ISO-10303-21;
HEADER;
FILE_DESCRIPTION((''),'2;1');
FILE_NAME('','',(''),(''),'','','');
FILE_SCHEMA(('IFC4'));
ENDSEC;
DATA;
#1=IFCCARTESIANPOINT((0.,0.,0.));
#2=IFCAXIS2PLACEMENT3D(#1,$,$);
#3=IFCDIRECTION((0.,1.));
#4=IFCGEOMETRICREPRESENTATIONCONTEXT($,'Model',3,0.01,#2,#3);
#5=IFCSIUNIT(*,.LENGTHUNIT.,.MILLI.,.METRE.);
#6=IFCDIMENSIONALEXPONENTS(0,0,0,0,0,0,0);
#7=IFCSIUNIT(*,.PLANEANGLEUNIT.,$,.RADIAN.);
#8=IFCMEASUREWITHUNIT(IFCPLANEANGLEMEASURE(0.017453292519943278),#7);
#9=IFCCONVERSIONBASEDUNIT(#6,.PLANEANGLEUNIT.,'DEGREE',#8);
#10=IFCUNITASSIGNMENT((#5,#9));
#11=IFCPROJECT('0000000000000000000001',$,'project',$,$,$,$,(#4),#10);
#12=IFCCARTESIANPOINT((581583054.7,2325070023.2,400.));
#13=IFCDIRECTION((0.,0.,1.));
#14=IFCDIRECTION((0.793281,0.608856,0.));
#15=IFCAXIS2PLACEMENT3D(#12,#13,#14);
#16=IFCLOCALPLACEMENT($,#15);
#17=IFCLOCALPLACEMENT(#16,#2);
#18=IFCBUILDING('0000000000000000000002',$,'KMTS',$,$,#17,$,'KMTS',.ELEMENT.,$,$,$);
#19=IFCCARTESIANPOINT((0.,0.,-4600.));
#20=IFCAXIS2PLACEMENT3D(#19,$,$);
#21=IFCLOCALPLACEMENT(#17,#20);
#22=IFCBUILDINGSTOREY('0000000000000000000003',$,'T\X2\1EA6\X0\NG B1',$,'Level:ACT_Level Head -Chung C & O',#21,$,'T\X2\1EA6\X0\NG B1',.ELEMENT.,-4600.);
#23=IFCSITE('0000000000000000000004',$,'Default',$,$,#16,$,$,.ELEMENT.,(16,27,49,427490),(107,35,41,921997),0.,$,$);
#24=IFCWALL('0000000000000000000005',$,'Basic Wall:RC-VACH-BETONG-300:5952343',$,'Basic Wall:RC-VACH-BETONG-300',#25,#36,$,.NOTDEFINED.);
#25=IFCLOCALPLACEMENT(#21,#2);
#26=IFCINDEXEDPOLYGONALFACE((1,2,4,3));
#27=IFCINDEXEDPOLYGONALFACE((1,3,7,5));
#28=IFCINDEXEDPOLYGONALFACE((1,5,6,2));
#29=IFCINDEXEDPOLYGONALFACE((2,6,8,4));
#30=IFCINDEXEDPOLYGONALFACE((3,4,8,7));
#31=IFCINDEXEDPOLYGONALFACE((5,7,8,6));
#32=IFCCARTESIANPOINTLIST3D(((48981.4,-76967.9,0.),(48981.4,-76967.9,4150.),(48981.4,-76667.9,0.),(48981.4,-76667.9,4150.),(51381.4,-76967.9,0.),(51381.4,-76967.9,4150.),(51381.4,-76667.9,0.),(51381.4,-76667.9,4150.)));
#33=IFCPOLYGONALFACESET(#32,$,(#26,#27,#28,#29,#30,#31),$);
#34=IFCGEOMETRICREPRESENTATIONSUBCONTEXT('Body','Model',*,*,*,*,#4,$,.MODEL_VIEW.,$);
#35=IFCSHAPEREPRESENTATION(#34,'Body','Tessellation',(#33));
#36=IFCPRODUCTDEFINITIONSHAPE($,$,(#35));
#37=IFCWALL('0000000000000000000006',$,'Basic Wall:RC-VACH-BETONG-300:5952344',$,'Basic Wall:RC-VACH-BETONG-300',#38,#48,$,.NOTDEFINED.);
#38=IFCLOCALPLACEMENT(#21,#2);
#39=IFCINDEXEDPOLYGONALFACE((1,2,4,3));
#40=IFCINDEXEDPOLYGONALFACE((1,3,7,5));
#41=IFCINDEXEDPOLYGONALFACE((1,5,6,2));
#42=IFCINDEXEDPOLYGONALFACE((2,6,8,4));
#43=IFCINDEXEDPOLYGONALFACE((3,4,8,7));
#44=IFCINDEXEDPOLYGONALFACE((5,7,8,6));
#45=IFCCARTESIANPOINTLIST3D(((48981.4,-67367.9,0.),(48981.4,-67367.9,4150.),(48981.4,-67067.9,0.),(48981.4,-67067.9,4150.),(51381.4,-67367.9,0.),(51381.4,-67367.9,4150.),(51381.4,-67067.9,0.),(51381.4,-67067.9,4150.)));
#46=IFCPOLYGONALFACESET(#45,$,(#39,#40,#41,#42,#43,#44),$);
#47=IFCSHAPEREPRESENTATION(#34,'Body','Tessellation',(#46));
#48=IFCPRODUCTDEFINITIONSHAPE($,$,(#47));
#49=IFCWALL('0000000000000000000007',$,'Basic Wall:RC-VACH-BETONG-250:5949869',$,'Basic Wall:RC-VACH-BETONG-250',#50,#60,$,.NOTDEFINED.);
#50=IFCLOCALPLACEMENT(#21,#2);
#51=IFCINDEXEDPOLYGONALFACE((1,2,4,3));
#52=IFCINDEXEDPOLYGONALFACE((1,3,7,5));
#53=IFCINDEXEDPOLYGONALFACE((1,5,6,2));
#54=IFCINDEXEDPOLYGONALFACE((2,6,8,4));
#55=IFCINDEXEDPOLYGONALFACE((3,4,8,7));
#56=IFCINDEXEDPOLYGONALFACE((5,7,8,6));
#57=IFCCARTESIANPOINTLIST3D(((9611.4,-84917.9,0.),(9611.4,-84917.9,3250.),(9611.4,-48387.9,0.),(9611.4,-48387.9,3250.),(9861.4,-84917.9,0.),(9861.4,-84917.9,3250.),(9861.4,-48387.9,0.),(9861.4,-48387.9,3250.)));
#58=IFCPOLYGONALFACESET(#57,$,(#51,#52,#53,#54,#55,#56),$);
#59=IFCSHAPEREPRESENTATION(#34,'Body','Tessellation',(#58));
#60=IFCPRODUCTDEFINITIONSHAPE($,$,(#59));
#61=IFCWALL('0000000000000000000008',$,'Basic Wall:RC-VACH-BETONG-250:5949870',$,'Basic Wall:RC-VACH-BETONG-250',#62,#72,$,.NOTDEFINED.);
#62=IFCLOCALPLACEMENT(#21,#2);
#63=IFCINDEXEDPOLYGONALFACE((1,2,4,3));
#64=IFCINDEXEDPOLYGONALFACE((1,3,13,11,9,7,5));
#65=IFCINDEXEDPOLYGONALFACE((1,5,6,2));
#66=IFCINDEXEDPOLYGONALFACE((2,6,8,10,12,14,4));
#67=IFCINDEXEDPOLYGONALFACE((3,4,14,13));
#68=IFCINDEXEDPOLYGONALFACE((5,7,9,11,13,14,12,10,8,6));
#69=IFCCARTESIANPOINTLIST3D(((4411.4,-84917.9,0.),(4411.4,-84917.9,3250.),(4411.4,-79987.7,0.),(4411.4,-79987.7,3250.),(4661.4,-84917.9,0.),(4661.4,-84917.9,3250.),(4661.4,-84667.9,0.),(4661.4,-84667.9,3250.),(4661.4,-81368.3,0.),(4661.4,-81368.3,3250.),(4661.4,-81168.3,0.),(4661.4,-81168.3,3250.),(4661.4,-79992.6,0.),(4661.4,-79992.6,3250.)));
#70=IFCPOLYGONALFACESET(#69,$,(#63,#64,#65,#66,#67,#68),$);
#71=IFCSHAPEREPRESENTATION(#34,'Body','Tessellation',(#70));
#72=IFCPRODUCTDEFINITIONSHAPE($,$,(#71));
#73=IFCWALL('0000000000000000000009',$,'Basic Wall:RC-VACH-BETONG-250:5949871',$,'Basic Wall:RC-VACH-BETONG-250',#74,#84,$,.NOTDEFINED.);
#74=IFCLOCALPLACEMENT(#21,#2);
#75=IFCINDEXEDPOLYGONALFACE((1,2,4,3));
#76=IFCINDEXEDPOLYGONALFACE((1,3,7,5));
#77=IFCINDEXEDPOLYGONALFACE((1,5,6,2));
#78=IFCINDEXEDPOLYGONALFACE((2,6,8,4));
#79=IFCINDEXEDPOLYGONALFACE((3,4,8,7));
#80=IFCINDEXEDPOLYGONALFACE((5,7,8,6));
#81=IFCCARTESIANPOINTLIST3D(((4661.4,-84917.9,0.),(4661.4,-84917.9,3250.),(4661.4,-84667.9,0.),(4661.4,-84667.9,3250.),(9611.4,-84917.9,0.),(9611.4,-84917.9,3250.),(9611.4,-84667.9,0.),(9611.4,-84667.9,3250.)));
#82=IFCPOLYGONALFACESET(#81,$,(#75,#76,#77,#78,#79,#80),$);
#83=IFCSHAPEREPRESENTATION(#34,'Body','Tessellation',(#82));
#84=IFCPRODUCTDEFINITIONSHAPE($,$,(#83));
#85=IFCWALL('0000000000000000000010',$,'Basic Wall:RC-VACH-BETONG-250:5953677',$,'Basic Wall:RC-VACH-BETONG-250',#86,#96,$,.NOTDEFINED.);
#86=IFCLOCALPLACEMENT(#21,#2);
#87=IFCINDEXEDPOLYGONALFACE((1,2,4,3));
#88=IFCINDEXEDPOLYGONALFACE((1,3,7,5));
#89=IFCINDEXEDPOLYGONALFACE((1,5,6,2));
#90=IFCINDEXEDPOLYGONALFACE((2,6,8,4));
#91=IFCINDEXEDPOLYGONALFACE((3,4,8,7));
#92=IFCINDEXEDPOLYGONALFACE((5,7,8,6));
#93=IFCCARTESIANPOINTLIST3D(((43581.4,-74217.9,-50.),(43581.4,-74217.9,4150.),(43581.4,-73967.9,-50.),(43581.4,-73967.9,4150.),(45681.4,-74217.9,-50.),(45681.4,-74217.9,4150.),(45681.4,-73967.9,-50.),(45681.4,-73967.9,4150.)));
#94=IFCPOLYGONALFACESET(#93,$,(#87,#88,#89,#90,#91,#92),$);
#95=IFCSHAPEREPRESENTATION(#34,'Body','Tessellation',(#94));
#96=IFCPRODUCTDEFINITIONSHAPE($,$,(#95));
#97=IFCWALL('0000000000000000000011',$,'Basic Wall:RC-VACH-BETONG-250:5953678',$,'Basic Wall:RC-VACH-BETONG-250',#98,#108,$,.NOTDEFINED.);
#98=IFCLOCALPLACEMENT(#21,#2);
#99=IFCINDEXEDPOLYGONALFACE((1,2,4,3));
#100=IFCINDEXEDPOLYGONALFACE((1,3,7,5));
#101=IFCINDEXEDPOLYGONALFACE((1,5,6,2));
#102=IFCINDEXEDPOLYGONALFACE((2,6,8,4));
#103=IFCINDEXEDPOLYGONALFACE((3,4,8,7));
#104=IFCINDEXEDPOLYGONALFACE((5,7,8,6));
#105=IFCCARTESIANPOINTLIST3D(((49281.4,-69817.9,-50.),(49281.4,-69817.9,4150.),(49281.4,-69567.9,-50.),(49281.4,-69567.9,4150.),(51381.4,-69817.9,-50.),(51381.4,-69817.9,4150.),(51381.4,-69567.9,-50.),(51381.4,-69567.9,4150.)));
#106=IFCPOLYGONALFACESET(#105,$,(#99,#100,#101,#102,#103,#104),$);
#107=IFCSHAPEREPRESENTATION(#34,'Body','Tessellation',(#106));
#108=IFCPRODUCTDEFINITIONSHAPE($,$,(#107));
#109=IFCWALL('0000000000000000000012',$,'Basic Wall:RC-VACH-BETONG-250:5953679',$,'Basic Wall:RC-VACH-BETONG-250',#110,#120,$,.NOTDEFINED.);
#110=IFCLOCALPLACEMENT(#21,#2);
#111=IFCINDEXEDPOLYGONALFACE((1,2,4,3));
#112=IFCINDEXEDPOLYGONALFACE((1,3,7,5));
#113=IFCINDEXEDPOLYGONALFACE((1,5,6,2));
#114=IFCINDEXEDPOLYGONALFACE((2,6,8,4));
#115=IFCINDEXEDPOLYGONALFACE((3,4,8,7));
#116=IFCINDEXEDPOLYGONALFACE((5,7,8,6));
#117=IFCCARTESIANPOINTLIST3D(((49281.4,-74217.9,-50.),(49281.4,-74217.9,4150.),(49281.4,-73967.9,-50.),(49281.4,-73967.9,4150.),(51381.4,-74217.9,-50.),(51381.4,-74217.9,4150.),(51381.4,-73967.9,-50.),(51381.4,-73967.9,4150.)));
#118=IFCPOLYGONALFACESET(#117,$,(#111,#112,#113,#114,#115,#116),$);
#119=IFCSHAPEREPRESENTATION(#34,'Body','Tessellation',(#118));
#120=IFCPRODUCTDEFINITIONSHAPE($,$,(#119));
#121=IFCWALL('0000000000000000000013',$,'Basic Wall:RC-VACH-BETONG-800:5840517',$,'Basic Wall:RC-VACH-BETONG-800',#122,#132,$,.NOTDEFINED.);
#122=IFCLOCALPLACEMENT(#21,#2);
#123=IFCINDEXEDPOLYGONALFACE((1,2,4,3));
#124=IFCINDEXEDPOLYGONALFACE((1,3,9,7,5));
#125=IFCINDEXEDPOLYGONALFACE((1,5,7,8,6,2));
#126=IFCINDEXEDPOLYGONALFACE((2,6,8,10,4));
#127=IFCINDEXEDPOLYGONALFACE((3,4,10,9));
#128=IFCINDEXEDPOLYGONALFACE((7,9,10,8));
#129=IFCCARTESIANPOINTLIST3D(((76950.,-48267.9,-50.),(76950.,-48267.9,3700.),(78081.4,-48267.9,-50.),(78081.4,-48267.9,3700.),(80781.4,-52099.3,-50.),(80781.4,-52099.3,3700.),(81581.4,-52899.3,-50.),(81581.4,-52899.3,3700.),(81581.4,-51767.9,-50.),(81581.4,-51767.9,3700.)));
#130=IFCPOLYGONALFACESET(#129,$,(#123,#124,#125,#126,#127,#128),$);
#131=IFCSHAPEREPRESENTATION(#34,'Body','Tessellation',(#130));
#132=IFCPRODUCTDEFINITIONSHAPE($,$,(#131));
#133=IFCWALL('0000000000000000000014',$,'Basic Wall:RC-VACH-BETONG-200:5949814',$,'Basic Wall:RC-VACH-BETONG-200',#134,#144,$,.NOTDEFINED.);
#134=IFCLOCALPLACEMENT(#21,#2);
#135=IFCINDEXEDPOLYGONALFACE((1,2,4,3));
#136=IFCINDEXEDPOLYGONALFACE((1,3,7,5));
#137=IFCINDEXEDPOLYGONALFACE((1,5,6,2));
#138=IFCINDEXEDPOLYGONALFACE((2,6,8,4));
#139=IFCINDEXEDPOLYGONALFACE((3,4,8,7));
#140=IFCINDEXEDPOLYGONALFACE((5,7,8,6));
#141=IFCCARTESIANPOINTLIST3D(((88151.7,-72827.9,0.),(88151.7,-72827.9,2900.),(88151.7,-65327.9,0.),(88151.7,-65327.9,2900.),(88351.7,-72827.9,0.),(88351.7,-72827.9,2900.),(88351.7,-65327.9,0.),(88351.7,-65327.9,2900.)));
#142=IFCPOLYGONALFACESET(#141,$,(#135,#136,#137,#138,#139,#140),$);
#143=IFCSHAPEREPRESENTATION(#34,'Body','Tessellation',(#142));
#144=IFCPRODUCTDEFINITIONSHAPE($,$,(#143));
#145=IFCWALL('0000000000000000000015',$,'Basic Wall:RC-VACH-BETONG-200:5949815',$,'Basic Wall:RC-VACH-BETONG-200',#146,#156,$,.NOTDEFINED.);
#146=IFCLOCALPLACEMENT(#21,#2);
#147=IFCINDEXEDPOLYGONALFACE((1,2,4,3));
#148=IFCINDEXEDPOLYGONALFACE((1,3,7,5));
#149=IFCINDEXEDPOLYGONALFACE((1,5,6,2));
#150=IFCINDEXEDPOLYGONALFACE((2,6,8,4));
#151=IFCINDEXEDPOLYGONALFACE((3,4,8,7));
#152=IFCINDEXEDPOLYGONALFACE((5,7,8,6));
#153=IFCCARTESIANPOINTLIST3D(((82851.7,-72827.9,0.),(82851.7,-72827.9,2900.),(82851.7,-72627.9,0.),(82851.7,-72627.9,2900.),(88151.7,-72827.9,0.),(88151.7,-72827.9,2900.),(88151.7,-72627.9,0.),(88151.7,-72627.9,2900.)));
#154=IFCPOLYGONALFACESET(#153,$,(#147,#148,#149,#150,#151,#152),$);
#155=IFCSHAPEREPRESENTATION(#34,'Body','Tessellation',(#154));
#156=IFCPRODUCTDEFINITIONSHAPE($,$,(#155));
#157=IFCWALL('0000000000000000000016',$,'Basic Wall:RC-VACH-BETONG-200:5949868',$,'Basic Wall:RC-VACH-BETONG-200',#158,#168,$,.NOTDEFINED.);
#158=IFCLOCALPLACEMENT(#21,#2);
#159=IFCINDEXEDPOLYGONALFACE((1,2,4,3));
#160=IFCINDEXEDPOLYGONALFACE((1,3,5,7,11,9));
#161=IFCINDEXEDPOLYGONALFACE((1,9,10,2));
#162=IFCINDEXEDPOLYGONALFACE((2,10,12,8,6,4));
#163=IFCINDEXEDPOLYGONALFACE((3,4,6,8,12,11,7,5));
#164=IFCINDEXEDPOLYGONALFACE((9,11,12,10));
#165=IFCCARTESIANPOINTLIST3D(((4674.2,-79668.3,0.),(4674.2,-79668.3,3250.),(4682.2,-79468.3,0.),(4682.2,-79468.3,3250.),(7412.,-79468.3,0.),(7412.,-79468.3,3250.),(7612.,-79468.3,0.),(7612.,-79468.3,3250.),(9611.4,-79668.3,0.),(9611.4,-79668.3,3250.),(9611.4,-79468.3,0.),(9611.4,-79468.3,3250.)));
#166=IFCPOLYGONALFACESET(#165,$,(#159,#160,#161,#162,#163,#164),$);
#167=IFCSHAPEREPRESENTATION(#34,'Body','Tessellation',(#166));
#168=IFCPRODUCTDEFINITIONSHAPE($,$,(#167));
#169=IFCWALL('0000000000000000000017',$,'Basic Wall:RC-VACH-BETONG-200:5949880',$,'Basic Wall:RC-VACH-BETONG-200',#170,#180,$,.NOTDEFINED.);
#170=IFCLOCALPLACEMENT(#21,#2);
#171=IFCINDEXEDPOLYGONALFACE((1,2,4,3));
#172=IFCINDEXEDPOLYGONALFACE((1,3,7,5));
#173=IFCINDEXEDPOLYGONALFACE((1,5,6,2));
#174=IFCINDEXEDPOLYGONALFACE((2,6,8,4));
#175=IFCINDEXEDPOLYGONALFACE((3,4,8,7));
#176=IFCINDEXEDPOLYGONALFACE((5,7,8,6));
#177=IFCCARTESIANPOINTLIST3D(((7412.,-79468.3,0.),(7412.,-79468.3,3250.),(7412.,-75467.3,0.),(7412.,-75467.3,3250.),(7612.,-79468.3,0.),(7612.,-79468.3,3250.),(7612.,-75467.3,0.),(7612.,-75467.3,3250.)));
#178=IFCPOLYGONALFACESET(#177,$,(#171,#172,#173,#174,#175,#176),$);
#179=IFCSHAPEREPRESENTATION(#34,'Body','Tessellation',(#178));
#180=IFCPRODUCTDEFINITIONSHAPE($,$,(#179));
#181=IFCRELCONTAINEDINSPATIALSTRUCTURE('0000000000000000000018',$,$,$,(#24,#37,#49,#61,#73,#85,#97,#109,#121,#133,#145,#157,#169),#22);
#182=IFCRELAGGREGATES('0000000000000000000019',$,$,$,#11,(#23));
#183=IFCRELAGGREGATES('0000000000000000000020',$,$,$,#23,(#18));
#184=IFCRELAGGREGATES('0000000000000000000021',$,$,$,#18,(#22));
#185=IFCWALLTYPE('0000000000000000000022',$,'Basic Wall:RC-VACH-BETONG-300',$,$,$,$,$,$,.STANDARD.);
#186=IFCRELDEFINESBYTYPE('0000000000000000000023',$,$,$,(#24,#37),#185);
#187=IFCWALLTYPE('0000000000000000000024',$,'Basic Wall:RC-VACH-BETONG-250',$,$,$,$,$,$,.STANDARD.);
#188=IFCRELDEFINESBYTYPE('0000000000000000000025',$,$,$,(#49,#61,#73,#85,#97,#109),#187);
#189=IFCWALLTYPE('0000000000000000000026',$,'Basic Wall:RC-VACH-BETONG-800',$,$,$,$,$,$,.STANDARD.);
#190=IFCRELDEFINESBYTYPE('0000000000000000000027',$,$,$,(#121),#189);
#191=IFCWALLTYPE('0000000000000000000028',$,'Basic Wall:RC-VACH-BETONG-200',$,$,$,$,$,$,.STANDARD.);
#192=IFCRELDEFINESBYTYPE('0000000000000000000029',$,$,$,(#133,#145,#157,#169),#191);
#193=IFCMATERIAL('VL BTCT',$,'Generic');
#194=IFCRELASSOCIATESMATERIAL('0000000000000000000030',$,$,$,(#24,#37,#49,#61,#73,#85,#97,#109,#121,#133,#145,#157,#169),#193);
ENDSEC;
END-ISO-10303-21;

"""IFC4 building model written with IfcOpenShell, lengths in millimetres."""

from ifc_helpers import new_model, entity, si_unit, converted_unit, direction, frame, origin, place, context, subcontext, project, spatial, indexed_curve, outline, extrude, material, type_object, element, save


model = new_model("IFC4")

# Units and contexts
model_context = context("Model", 3, precision=0.01, world=origin(), true_north=direction((0.0, 1.0)))
body_context = subcontext(model_context, "Body", "Model", "MODEL_VIEW")
ifc_project = project(units=[si_unit("LENGTHUNIT", "METRE", prefix="MILLI"), converted_unit("PLANEANGLEUNIT", "DEGREE", entity("IfcPlaneAngleMeasure", 0.017453292519943278), si_unit("PLANEANGLEUNIT", "RADIAN"), dimensions=[0, 0, 0, 0, 0, 0, 0])], contexts=[model_context])

# Site, building, storey
site_placement = place(None, frame((581583054.7, 2325070023.2, 400.0), z_axis=(0.0, 0.0, 1.0), x_axis=(0.793281, 0.608856, 0.0)))
site = spatial("IfcSite", under=ifc_project, at=site_placement, Name="Default", CompositionType="ELEMENT", RefLatitude=(16, 27, 49, 427490), RefLongitude=(107, 35, 41, 921997), RefElevation=0.0)
building_placement = place(site_placement, origin())
building = spatial("IfcBuilding", under=site, at=building_placement, Name="KMTS", LongName="KMTS", CompositionType="ELEMENT")
storey_placement = place(building_placement, frame((0.0, 0.0, -4600.0)))
storey = spatial("IfcBuildingStorey", under=building, at=storey_placement, Name="TẦNG B1", ObjectType="Level:ACT_Level Head -Chung C & O", LongName="TẦNG B1", CompositionType="ELEMENT", Elevation=-4600.0)

# Shared definitions
ifc_material_1 = material(Name="VL BTCT", Category="Generic")

# Walls
wall_type_1 = type_object("IfcWallType", Name="Basic Wall:RC-VACH-BETONG-300", PredefinedType="STANDARD")
wall_1_placement = place(storey_placement, frame((51381.4, -76817.9, 0.0), z_axis=(0.0, 0.0, 1.0), x_axis=(-1.0, 0.0, 0.0)))
element("IfcWall", 1, at=wall_1_placement, inside=storey, type_object=wall_type_1, material=ifc_material_1, Name="Basic Wall:RC-VACH-BETONG-300:5952343", ObjectType="Basic Wall:RC-VACH-BETONG-300", PredefinedType="NOTDEFINED", context=body_context, shape_type="SweptSolid", body=[
    extrude(outline(indexed_curve([(2400.0, 150.0), (0.0, 150.0), (0.0, -150.0), (2400.0, -150.0), (2400.0, 150.0)], self_intersect=False)), origin(), (0.0, 0.0, 1.0), 4150.0),
])
wall_2_placement = place(storey_placement, frame((51381.4, -67217.9, 0.0), z_axis=(0.0, 0.0, 1.0), x_axis=(-1.0, 0.0, 0.0)))
element("IfcWall", 2, at=wall_2_placement, inside=storey, type_object=wall_type_1, material=ifc_material_1, Name="Basic Wall:RC-VACH-BETONG-300:5952344", ObjectType="Basic Wall:RC-VACH-BETONG-300", PredefinedType="NOTDEFINED", context=body_context, shape_type="SweptSolid", body=[
    extrude(outline(indexed_curve([(2400.0, 150.0), (0.0, 150.0), (0.0, -150.0), (2400.0, -150.0), (2400.0, 150.0)], self_intersect=False)), origin(), (0.0, 0.0, 1.0), 4150.0),
])
wall_type_2 = type_object("IfcWallType", Name="Basic Wall:RC-VACH-BETONG-250", PredefinedType="STANDARD")
wall_3_placement = place(storey_placement, frame((9736.4, -84917.9, 0.0), z_axis=(0.0, 0.0, 1.0), x_axis=(0.0, 1.0, 0.0)))
element("IfcWall", 3, at=wall_3_placement, inside=storey, type_object=wall_type_2, material=ifc_material_1, Name="Basic Wall:RC-VACH-BETONG-250:5949869", ObjectType="Basic Wall:RC-VACH-BETONG-250", PredefinedType="NOTDEFINED", context=body_context, shape_type="SweptSolid", body=[
    extrude(outline(indexed_curve([(36530.0, 125.0), (0.0, 125.0), (0.0, -125.0), (36530.0, -125.0), (36530.0, 125.0)], self_intersect=False)), origin(), (0.0, 0.0, 1.0), 3250.0),
])
wall_4_placement = place(storey_placement, frame((4536.4, -84917.9, 0.0), z_axis=(0.0, 0.0, 1.0), x_axis=(0.0, 1.0, 0.0)))
element("IfcWall", 4, at=wall_4_placement, inside=storey, type_object=wall_type_2, material=ifc_material_1, Name="Basic Wall:RC-VACH-BETONG-250:5949870", ObjectType="Basic Wall:RC-VACH-BETONG-250", PredefinedType="NOTDEFINED", context=body_context, shape_type="SweptSolid", body=[
    extrude(outline(indexed_curve([(4925.3, -125.0), (4930.3, 125.0), (0.0, 125.0), (0.0, -125.0), (250.0, -125.0), (3549.7, -125.0), (3749.7, -125.0), (4925.3, -125.0)], self_intersect=False)), origin(), (0.0, 0.0, 1.0), 3250.0),
])
wall_5_placement = place(storey_placement, frame((9611.4, -84792.9, 0.0), z_axis=(0.0, 0.0, 1.0), x_axis=(-1.0, 0.0, 0.0)))
element("IfcWall", 5, at=wall_5_placement, inside=storey, type_object=wall_type_2, material=ifc_material_1, Name="Basic Wall:RC-VACH-BETONG-250:5949871", ObjectType="Basic Wall:RC-VACH-BETONG-250", PredefinedType="NOTDEFINED", context=body_context, shape_type="SweptSolid", body=[
    extrude(outline(indexed_curve([(4950.0, 125.0), (0.0, 125.0), (0.0, -125.0), (4950.0, -125.0), (4950.0, 125.0)], self_intersect=False)), origin(), (0.0, 0.0, 1.0), 3250.0),
])
wall_6_placement = place(storey_placement, frame((45681.4, -74092.9, -50.0), z_axis=(0.0, 0.0, 1.0), x_axis=(-1.0, 0.0, 0.0)))
element("IfcWall", 6, at=wall_6_placement, inside=storey, type_object=wall_type_2, material=ifc_material_1, Name="Basic Wall:RC-VACH-BETONG-250:5953677", ObjectType="Basic Wall:RC-VACH-BETONG-250", PredefinedType="NOTDEFINED", context=body_context, shape_type="SweptSolid", body=[
    extrude(outline(indexed_curve([(2100.0, 125.0), (0.0, 125.0), (0.0, -125.0), (2100.0, -125.0), (2100.0, 125.0)], self_intersect=False)), origin(), (0.0, 0.0, 1.0), 4200.0),
])
for number, where, z_axis, x_axis, name in (
    (7, (51381.4, -69692.9, -50.0), (0.0, 0.0, 1.0), (-1.0, 0.0, 0.0), "Basic Wall:RC-VACH-BETONG-250:5953678"),
    (8, (51381.4, -74092.9, -50.0), (0.0, 0.0, 1.0), (-1.0, 0.0, 0.0), "Basic Wall:RC-VACH-BETONG-250:5953679"),
):
    element("IfcWall", number, at=place(storey_placement, frame(where, z_axis=z_axis, x_axis=x_axis)), inside=storey, type_object=wall_type_2, material=ifc_material_1, Name=name, ObjectType="Basic Wall:RC-VACH-BETONG-250", PredefinedType="NOTDEFINED", context=body_context, shape_type="SweptSolid", body=[
        extrude(outline(indexed_curve([(2100.0, 125.0), (0.0, 125.0), (0.0, -125.0), (2100.0, -125.0), (2100.0, 125.0)], self_intersect=False)), origin(), (0.0, 0.0, 1.0), 4200.0),
    ])
wall_type_3 = type_object("IfcWallType", Name="Basic Wall:RC-VACH-BETONG-800", PredefinedType="STANDARD")
wall_7_placement = place(storey_placement, frame((77232.9, -47985.1, -50.0), z_axis=(0.0, 0.0, 1.0), x_axis=(0.707107, -0.707107, 0.0)))
element("IfcWall", 9, at=wall_7_placement, inside=storey, type_object=wall_type_3, material=ifc_material_1, Name="Basic Wall:RC-VACH-BETONG-800:5840517", ObjectType="Basic Wall:RC-VACH-BETONG-800", PredefinedType="NOTDEFINED", context=body_context, shape_type="SweptSolid", body=[
    extrude(outline(indexed_curve([(6549.7, -400.0), (5749.7, 400.0), (800.0, 400.0), (0.0, -400.0), (5418.4, -400.0), (6549.7, -400.0)], self_intersect=False)), origin(), (0.0, 0.0, 1.0), 3750.0),
])
wall_type_4 = type_object("IfcWallType", Name="Basic Wall:RC-VACH-BETONG-200", PredefinedType="STANDARD")
wall_8_placement = place(storey_placement, frame((88251.7, -65327.9, 0.0), z_axis=(0.0, 0.0, 1.0), x_axis=(0.0, -1.0, 0.0)))
element("IfcWall", 10, at=wall_8_placement, inside=storey, type_object=wall_type_4, material=ifc_material_1, Name="Basic Wall:RC-VACH-BETONG-200:5949814", ObjectType="Basic Wall:RC-VACH-BETONG-200", PredefinedType="NOTDEFINED", context=body_context, shape_type="SweptSolid", body=[
    extrude(outline(indexed_curve([(7500.0, 100.0), (0.0, 100.0), (0.0, -100.0), (7500.0, -100.0), (7500.0, 100.0)], self_intersect=False)), origin(), (0.0, 0.0, 1.0), 2900.0),
])
wall_9_placement = place(storey_placement, frame((88151.7, -72727.9, 0.0), z_axis=(0.0, 0.0, 1.0), x_axis=(-1.0, 0.0, 0.0)))
element("IfcWall", 11, at=wall_9_placement, inside=storey, type_object=wall_type_4, material=ifc_material_1, Name="Basic Wall:RC-VACH-BETONG-200:5949815", ObjectType="Basic Wall:RC-VACH-BETONG-200", PredefinedType="NOTDEFINED", context=body_context, shape_type="SweptSolid", body=[
    extrude(outline(indexed_curve([(5300.0, 100.0), (0.0, 100.0), (0.0, -100.0), (5300.0, -100.0), (5300.0, 100.0)], self_intersect=False)), origin(), (0.0, 0.0, 1.0), 2900.0),
])
wall_10_placement = place(storey_placement, frame((9611.4, -79568.3, 0.0), z_axis=(0.0, 0.0, 1.0), x_axis=(-1.0, 0.0, 0.0)))
element("IfcWall", 12, at=wall_10_placement, inside=storey, type_object=wall_type_4, material=ifc_material_1, Name="Basic Wall:RC-VACH-BETONG-200:5949868", ObjectType="Basic Wall:RC-VACH-BETONG-200", PredefinedType="NOTDEFINED", context=body_context, shape_type="SweptSolid", body=[
    extrude(outline(indexed_curve([(4929.2, -100.0), (4937.1, 100.0), (0.0, 100.0), (0.0, -100.0), (1999.4, -100.0), (2199.4, -100.0), (4929.2, -100.0)], self_intersect=False)), origin(), (0.0, 0.0, 1.0), 3250.0),
])
wall_11_placement = place(storey_placement, frame((7512.0, -79468.3, 0.0), z_axis=(0.0, 0.0, 1.0), x_axis=(0.0, 1.0, 0.0)))
element("IfcWall", 13, at=wall_11_placement, inside=storey, type_object=wall_type_4, material=ifc_material_1, Name="Basic Wall:RC-VACH-BETONG-200:5949880", ObjectType="Basic Wall:RC-VACH-BETONG-200", PredefinedType="NOTDEFINED", context=body_context, shape_type="SweptSolid", body=[
    extrude(outline(indexed_curve([(4000.9, 100.0), (0.0, 100.0), (0.0, -100.0), (4000.9, -100.0), (4000.9, 100.0)], self_intersect=False)), origin(), (0.0, 0.0, 1.0), 3250.0),
])

save(model, "model.ifc")
